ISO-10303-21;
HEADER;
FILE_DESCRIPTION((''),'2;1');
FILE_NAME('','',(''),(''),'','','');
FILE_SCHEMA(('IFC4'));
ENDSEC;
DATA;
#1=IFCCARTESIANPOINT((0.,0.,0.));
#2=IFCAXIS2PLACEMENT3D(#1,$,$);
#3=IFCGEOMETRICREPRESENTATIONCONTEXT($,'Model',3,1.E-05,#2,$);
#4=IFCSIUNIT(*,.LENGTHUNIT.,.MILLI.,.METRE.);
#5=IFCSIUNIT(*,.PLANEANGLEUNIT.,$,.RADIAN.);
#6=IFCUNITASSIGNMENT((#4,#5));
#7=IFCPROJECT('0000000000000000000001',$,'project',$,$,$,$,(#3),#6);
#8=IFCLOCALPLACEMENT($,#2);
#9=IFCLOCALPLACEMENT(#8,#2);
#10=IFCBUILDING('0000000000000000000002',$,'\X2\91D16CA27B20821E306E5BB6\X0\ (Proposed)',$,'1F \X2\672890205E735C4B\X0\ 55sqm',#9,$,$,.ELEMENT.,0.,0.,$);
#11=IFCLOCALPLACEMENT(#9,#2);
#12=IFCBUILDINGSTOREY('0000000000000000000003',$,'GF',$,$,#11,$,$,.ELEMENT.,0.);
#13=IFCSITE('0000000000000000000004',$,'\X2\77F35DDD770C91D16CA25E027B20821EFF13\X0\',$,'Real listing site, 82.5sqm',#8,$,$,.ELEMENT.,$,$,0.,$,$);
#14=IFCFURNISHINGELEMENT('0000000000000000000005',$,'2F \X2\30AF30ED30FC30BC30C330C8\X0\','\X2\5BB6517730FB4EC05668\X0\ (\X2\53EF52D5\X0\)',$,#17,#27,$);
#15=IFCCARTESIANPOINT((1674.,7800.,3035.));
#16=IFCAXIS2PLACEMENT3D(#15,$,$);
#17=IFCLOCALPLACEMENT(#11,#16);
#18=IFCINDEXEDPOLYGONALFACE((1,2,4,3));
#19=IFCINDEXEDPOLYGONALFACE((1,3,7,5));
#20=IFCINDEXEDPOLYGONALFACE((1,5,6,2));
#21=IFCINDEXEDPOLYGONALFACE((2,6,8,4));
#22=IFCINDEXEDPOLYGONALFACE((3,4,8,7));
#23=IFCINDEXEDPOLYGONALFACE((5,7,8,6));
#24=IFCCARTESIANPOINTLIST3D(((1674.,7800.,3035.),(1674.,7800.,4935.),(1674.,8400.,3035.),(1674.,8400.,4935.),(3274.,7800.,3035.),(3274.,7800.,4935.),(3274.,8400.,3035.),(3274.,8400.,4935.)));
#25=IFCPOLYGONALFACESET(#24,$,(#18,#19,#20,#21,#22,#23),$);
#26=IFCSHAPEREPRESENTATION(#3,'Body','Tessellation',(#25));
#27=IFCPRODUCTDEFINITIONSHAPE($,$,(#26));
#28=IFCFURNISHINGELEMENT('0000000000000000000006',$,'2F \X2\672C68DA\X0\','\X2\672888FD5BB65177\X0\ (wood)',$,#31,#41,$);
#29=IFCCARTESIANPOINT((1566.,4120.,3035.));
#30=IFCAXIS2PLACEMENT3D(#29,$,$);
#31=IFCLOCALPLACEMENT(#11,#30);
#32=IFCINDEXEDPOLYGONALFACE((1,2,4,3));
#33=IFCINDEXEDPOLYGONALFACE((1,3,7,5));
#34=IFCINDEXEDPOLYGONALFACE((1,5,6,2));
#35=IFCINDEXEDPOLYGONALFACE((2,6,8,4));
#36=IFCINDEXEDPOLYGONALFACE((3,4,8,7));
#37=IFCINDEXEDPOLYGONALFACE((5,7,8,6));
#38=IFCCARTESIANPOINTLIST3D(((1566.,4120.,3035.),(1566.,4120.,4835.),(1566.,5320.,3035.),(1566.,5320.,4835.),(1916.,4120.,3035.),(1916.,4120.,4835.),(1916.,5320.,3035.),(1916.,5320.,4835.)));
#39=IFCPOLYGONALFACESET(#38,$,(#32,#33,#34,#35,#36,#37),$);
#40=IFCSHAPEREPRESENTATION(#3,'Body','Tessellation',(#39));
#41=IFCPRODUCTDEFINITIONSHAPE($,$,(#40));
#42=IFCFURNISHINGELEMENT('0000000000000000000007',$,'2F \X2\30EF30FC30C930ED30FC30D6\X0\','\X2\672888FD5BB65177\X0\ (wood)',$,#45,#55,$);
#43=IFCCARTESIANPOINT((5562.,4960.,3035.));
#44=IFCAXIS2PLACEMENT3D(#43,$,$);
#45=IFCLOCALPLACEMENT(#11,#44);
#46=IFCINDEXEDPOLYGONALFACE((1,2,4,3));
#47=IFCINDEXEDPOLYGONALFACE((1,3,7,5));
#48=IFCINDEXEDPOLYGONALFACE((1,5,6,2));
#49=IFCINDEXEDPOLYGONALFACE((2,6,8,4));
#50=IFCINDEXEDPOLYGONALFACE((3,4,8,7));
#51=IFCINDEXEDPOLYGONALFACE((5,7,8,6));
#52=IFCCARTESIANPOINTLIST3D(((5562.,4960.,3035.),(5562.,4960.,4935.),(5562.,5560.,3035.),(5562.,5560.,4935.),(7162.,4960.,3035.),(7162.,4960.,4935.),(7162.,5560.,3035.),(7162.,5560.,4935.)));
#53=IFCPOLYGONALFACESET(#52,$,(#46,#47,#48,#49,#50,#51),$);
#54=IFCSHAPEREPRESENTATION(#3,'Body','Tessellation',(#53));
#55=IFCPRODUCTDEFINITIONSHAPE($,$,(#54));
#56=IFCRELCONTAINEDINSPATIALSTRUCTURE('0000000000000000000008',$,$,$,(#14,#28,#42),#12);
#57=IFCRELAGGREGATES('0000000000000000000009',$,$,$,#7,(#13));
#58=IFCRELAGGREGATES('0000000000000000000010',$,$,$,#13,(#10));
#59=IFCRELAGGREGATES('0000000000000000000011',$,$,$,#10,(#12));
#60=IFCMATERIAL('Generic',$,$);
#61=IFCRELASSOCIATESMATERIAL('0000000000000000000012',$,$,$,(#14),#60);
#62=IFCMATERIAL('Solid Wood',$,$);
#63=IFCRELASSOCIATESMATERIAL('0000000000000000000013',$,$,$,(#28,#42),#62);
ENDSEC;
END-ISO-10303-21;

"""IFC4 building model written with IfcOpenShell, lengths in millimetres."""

from ifc_helpers import new_model, si_unit, frame, frame_2d, origin, place, context, project, spatial, rectangle, extrude, material, element, save


model = new_model("IFC4")

# Units and contexts
model_context = context("Model", 3, precision=1e-05, world=origin())
ifc_project = project(units=[si_unit("LENGTHUNIT", "METRE", prefix="MILLI"), si_unit("PLANEANGLEUNIT", "RADIAN")], contexts=[model_context])

# Site, building, storey
site_placement = place(None, origin())
site = spatial("IfcSite", under=ifc_project, at=site_placement, Name="石川県金沢市笠舞３", ObjectType="Real listing site, 82.5sqm", CompositionType="ELEMENT", RefElevation=0.0)
building_placement = place(site_placement, origin())
building = spatial("IfcBuilding", under=site, at=building_placement, Name="金沢笠舞の家 (Proposed)", ObjectType="1F 木造平屋 55sqm", CompositionType="ELEMENT", ElevationOfRefHeight=0.0, ElevationOfTerrain=0.0)
storey_placement = place(building_placement, origin())
storey = spatial("IfcBuildingStorey", under=building, at=storey_placement, Name="GF", CompositionType="ELEMENT", Elevation=0.0)

# Shared definitions
ifc_material_1 = material(Name="Solid Wood")

# Shared definitions
ifc_material_2 = material(Name="Generic")

# Furnishing elements
furnishing_1_placement = place(storey_placement, frame((1674.0, 7800.0, 3035.0)))
element("IfcFurnishingElement", 1, at=furnishing_1_placement, inside=storey, material=ifc_material_2, Name="2F クローゼット", Description="家具・什器 (可動)", context=model_context, shape_type="SweptSolid", body=[
    extrude(rectangle(XDim=1600.0, YDim=600.0, at=frame_2d((800.0, 300.0))), frame((1674.0, 7800.0, 3035.0)), (0.0, 0.0, 1.0), 1900.0),
])
furnishing_2_placement = place(storey_placement, frame((1566.0, 4120.0, 3035.0)))
element("IfcFurnishingElement", 2, at=furnishing_2_placement, inside=storey, material=ifc_material_1, Name="2F 本棚", Description="木製家具 (wood)", context=model_context, shape_type="SweptSolid", body=[
    extrude(rectangle(XDim=350.0, YDim=1200.0, at=frame_2d((175.0, 600.0))), frame((1566.0, 4120.0, 3035.0)), (0.0, 0.0, 1.0), 1800.0),
])
furnishing_3_placement = place(storey_placement, frame((5562.0, 4960.0, 3035.0)))
element("IfcFurnishingElement", 3, at=furnishing_3_placement, inside=storey, material=ifc_material_1, Name="2F ワードローブ", Description="木製家具 (wood)", context=model_context, shape_type="SweptSolid", body=[
    extrude(rectangle(XDim=1600.0, YDim=600.0, at=frame_2d((800.0, 300.0))), frame((5562.0, 4960.0, 3035.0)), (0.0, 0.0, 1.0), 1900.0),
])

save(model, "model.ifc")
